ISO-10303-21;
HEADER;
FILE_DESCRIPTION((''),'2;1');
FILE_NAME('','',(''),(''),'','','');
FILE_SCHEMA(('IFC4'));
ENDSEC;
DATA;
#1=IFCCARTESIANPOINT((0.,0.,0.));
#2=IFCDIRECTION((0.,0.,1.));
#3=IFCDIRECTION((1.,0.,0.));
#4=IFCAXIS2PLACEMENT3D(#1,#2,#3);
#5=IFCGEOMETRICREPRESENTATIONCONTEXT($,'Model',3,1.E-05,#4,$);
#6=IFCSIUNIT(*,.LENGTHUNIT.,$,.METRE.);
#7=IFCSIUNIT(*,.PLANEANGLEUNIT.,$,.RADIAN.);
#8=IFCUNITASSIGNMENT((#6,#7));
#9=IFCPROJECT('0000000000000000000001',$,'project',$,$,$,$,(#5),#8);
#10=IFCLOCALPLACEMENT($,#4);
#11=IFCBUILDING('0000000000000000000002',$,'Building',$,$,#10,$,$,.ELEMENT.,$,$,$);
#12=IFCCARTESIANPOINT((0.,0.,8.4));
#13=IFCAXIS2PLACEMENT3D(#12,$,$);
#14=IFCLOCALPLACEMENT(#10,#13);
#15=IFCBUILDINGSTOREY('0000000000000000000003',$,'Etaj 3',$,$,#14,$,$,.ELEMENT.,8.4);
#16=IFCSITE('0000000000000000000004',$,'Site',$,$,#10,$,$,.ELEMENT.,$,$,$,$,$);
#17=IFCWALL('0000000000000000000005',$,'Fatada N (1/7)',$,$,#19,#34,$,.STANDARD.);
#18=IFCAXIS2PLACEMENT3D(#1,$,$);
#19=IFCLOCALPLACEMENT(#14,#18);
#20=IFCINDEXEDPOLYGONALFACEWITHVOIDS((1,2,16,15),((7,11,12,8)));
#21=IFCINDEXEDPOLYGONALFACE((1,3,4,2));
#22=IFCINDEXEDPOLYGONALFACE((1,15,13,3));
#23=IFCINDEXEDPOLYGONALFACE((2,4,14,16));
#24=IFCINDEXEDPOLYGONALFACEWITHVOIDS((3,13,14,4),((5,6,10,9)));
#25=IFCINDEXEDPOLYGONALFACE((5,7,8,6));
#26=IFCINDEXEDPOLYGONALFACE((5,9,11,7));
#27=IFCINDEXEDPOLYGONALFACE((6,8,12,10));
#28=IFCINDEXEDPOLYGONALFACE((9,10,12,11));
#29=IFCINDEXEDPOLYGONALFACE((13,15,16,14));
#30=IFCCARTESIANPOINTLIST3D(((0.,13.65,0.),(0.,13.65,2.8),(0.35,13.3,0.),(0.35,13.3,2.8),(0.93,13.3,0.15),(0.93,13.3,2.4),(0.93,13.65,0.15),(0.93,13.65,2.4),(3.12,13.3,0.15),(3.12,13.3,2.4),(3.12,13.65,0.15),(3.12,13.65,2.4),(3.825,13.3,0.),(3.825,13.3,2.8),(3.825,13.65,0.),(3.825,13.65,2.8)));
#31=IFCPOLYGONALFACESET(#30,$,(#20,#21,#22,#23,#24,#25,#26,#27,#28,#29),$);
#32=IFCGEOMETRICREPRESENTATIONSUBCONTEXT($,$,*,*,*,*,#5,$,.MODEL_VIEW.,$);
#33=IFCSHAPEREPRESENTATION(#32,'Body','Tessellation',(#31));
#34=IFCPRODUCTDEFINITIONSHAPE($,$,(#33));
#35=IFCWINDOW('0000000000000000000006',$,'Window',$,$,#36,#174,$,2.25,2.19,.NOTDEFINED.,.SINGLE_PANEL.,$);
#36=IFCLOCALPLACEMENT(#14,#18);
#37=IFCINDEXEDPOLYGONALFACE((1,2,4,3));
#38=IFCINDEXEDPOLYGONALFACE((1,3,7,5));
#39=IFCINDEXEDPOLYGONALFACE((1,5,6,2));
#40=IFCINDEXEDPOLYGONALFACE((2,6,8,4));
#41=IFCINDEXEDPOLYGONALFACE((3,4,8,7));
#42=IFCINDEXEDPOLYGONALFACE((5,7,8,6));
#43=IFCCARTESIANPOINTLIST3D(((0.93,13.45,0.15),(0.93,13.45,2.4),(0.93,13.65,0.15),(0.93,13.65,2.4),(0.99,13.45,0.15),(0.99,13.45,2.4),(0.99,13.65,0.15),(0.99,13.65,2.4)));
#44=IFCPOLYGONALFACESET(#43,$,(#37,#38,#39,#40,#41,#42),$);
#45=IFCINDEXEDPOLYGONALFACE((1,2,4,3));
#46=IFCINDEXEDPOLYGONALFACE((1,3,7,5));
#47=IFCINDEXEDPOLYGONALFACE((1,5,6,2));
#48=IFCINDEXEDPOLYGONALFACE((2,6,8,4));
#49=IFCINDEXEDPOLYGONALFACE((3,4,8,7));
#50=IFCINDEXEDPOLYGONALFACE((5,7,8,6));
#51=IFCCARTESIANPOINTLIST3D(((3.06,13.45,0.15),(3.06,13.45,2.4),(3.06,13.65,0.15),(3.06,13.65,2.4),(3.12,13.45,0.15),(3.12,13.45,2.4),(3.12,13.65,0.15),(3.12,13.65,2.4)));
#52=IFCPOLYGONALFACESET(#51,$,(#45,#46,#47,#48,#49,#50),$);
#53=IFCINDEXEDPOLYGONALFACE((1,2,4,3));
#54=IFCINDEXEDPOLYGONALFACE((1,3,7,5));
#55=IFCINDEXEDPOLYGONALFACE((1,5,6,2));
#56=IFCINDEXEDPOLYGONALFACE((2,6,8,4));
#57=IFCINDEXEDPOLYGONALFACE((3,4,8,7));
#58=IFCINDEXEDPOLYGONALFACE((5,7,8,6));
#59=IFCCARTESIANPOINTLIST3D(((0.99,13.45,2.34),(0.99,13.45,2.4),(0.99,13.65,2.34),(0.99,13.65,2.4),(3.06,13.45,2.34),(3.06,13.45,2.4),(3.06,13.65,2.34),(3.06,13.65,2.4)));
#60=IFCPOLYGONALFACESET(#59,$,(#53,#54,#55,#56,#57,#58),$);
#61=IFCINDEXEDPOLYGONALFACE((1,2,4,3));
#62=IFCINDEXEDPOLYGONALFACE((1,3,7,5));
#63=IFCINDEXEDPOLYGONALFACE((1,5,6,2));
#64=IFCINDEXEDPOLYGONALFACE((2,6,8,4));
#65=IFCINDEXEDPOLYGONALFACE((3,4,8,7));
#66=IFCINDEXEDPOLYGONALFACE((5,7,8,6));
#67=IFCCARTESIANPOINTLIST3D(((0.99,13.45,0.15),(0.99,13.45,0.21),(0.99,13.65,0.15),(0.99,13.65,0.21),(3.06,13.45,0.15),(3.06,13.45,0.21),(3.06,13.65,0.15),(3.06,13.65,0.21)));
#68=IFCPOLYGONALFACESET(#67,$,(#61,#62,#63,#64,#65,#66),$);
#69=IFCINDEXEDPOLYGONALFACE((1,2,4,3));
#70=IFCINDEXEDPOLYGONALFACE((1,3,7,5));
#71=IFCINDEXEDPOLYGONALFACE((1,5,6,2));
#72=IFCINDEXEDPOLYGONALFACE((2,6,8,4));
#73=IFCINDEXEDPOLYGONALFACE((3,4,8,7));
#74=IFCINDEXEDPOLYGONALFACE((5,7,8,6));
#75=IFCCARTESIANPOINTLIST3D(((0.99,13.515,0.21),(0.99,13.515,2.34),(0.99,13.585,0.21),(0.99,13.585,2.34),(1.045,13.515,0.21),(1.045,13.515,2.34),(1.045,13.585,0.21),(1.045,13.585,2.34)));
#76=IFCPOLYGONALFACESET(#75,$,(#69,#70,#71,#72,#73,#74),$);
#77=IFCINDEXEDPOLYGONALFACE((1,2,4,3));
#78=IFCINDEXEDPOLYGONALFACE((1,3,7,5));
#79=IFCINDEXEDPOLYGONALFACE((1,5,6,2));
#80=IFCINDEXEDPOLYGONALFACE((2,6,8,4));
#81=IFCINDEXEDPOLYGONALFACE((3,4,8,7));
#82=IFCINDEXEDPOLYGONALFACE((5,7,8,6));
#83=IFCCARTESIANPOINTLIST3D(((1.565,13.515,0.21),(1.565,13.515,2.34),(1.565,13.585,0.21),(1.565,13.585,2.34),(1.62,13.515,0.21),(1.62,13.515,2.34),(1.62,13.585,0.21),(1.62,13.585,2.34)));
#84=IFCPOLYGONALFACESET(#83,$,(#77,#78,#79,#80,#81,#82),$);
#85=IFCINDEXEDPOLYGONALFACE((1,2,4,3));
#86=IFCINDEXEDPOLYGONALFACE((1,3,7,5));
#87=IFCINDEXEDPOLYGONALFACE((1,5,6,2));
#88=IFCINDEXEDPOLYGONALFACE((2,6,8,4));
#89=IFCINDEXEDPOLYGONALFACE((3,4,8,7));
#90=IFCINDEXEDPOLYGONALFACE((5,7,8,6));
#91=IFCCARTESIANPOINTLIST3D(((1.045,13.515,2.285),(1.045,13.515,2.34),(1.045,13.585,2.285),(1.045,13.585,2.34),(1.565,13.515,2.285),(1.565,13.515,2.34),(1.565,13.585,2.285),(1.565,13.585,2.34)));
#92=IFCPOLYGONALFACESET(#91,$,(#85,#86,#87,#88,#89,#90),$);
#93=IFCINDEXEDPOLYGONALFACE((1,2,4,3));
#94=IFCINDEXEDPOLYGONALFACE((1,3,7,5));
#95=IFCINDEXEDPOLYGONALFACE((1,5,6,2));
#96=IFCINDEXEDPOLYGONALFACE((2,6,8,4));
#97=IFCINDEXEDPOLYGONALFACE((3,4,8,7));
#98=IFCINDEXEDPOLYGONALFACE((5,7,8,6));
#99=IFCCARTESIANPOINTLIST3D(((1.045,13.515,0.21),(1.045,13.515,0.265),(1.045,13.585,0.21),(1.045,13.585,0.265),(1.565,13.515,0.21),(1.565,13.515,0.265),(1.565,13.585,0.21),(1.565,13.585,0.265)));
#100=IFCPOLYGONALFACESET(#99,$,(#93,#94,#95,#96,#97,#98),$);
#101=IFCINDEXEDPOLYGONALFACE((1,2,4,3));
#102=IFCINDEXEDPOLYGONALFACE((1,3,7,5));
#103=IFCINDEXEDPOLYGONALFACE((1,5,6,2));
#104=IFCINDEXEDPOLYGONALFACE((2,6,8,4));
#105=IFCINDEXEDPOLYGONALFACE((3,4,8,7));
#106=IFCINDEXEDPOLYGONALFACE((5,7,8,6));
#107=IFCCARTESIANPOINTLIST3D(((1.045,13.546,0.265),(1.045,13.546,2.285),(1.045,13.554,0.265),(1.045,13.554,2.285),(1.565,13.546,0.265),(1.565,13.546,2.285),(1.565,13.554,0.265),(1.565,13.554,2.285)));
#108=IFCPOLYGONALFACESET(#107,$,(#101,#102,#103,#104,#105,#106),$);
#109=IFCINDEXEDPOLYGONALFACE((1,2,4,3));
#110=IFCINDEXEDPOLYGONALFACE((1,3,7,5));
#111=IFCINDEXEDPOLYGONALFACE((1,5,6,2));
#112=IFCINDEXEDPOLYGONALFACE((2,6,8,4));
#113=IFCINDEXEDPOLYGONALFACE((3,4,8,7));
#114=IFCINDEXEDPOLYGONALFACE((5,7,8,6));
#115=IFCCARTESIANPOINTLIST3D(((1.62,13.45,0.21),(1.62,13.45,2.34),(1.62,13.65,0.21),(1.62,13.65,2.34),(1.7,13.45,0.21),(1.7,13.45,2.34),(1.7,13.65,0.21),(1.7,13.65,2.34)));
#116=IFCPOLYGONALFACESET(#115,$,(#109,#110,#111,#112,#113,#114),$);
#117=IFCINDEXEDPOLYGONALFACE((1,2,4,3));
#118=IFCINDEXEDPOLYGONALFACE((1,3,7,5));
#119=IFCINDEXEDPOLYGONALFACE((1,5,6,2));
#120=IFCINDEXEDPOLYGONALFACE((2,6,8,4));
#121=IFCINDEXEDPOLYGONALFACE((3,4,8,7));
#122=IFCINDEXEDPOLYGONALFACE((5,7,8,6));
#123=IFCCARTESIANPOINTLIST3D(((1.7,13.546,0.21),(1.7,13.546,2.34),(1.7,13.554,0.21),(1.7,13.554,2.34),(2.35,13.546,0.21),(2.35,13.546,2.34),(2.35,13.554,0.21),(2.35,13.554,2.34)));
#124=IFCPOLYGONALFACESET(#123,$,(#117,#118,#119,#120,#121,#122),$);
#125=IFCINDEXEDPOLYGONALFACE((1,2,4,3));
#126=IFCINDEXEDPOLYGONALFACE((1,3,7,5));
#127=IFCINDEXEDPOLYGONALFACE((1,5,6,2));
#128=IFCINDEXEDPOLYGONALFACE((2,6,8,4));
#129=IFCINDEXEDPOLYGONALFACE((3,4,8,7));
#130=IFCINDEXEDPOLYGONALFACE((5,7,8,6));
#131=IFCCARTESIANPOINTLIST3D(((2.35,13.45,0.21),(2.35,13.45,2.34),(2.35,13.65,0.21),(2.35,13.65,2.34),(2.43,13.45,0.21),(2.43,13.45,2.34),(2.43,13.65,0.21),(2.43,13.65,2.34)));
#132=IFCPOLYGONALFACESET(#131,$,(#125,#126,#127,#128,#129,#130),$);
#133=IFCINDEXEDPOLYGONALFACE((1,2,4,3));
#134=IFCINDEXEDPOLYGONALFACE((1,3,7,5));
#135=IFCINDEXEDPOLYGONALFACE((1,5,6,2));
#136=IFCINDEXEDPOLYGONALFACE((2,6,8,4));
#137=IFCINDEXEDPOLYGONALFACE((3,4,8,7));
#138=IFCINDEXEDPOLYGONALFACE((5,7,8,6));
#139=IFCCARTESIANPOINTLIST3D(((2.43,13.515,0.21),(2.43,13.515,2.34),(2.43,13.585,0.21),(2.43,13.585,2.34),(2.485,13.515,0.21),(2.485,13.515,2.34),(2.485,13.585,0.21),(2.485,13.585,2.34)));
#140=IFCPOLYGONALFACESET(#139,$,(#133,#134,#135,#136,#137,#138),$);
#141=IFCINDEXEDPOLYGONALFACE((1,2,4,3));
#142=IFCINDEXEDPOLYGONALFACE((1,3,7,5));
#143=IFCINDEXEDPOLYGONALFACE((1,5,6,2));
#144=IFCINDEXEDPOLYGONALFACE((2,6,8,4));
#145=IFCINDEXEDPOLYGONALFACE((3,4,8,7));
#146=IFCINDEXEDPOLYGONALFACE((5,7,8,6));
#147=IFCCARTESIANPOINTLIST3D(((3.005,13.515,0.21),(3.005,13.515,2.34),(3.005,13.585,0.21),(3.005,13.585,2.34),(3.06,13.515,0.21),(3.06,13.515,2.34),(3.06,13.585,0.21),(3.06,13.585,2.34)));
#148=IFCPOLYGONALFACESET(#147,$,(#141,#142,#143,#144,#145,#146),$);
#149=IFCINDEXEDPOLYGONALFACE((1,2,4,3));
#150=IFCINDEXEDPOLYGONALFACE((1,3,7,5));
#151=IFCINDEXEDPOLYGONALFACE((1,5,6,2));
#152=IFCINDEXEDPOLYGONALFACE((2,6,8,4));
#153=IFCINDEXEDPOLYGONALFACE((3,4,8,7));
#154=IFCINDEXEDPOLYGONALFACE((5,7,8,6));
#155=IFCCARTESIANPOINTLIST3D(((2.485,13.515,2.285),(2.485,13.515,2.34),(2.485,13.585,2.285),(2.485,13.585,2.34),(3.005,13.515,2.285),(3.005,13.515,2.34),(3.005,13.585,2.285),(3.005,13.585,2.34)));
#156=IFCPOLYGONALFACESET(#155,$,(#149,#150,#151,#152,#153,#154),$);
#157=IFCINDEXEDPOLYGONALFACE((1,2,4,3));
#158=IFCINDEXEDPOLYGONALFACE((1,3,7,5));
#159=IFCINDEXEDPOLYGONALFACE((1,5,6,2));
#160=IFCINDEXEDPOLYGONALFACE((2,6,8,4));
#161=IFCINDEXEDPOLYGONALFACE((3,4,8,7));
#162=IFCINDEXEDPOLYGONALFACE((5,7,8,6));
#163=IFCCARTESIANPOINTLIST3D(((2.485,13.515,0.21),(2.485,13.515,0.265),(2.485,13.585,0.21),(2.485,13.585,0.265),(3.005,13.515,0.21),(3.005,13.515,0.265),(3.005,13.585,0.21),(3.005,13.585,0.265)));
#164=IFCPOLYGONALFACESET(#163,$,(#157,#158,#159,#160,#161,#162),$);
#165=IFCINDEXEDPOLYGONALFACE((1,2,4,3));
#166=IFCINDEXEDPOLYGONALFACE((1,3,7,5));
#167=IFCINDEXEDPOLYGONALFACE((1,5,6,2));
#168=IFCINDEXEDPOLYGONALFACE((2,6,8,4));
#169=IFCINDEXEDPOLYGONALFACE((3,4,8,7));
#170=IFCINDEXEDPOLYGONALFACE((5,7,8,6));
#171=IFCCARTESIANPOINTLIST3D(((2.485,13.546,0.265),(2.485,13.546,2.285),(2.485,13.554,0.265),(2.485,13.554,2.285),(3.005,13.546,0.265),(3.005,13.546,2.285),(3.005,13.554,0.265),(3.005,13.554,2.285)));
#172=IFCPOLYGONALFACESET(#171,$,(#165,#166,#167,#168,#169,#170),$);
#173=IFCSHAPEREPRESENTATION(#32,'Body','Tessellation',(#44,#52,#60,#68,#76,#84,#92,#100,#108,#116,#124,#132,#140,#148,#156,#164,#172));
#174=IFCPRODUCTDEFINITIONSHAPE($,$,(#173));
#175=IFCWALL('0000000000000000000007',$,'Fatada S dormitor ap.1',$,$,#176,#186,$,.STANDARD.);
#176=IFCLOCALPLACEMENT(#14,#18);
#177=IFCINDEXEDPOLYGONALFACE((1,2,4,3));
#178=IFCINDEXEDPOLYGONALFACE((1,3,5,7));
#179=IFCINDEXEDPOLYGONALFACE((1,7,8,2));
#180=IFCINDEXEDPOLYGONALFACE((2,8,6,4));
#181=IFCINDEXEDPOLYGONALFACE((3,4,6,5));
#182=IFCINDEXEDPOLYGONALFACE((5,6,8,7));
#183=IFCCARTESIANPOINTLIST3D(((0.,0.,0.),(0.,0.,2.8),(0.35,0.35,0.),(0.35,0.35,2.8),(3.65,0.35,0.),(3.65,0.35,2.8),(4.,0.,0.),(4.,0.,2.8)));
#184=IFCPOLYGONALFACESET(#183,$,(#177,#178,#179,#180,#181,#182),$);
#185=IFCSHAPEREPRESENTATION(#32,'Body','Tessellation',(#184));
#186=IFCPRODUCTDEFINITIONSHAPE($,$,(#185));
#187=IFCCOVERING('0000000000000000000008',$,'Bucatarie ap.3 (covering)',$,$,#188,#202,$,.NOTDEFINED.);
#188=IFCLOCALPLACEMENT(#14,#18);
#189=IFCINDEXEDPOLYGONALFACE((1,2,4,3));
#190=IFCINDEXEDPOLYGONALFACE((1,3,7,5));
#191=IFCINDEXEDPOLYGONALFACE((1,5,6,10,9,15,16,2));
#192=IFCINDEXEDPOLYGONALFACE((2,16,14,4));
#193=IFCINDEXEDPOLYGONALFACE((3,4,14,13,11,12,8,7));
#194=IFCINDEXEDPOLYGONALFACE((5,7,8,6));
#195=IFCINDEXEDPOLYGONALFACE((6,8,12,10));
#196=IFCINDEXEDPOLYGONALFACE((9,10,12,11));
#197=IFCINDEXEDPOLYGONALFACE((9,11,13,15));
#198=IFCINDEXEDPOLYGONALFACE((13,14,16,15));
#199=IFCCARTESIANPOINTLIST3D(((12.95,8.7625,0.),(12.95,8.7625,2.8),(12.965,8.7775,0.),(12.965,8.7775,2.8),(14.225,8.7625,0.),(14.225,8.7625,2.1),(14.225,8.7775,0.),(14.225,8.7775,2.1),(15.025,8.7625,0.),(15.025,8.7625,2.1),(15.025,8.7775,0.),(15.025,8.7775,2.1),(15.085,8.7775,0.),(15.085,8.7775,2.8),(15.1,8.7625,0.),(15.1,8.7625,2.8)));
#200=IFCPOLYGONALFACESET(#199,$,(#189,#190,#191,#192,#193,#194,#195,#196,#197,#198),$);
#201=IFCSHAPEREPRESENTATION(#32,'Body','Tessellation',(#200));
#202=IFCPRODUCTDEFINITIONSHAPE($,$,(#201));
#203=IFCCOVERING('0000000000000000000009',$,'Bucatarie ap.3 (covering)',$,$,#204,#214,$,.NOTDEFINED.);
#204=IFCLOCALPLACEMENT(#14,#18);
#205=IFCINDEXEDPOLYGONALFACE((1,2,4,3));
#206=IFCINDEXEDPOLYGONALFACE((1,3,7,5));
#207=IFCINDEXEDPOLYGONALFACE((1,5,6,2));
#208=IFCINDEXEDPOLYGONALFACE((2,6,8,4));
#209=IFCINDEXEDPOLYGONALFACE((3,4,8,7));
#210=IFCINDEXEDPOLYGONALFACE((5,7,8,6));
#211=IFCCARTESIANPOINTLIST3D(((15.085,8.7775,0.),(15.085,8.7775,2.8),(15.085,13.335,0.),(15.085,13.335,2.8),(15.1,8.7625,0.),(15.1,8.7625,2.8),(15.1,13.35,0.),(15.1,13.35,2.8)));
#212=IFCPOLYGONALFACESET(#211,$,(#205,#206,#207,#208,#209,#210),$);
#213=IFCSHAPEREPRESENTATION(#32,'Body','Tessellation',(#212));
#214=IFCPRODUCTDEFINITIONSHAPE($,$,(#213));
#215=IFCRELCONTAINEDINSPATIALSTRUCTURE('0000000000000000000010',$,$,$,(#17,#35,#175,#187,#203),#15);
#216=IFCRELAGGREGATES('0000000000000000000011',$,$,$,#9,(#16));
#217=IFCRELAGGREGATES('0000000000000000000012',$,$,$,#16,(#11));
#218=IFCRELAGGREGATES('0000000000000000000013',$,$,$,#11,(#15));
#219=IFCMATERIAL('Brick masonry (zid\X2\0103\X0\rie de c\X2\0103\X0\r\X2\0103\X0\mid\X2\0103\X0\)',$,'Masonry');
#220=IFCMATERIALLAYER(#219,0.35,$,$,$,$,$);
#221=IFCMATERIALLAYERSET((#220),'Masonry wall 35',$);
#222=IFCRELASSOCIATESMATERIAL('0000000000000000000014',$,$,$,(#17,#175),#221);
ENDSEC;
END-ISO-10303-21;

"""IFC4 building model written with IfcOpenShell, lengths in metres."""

from ifc_helpers import new_model, si_unit, frame, frame_2d, origin, origin_with_axes, origin_2d, place, context, subcontext, project, spatial, polyline, rectangle, outline, extrude, clip, halfspace, material, layer, layer_set, layer_usage, element, fill, save


model = new_model("IFC4")

# Units and contexts
model_context = context("Model", 3, precision=1e-05, world=origin_with_axes())
sub_context = subcontext(model_context, None, None, "MODEL_VIEW")
ifc_project = project(units=[si_unit("LENGTHUNIT", "METRE"), si_unit("PLANEANGLEUNIT", "RADIAN")], contexts=[model_context])

# Site, building, storey
placement = place(None, origin_with_axes())
site = spatial("IfcSite", under=ifc_project, at=placement, Name="Site", CompositionType="ELEMENT")
building = spatial("IfcBuilding", under=site, at=placement, Name="Building", CompositionType="ELEMENT")
storey_placement = place(placement, frame((0.0, 0.0, 8.4)))
storey = spatial("IfcBuildingStorey", under=building, at=storey_placement, Name="Etaj 3", CompositionType="ELEMENT", Elevation=8.4)

# Wall, opening, window
ifc_material = material(Name="Brick masonry (zidărie de cărămidă)", Category="Masonry")
ifc_layer = layer(ifc_material, 0.35)
ifc_layer_set = layer_set([ifc_layer], Name="Masonry wall 35")
ifc_layer_usage = layer_usage(ifc_layer_set, "AXIS2", "POSITIVE", -0.175)
wall_1_placement = place(storey_placement, frame((0.0, 13.475, 0.0), x_axis=(1.0, 0.0, 0.0)))
wall_1 = element("IfcWall", 1, at=wall_1_placement, inside=storey, material=ifc_layer_usage, Name="Fatada N (1/7)", PredefinedType="STANDARD", context=sub_context, shape_type="CSG", body=[
    clip(extrude(rectangle(XDim=3.825, YDim=0.35, at=frame_2d((1.9125, 0.0))), origin(), (0.0, 0.0, 1.0), 2.8), halfspace(frame((0.175, 0.0, 0.0), z_axis=(-0.707107, -0.707107, 0.0)), False)),
])
opening_1_placement = place(wall_1_placement, frame((2.025, 0.225, 0.15), z_axis=(0.0, -1.0, 0.0), x_axis=(1.0, 0.0, 0.0)))
opening_1 = element("IfcOpeningElement", 2, at=opening_1_placement, cuts=wall_1, PredefinedType="OPENING", context=sub_context, shape_type="SweptSolid", body=[
    extrude(rectangle(XDim=2.19, YDim=2.25, at=frame_2d((0.0, 1.125))), origin(), (0.0, 0.0, 1.0), 0.45),
])
window_placement = place(wall_1_placement, frame((2.025, 0.175, 0.15), z_axis=(0.0, -1.0, 0.0), x_axis=(1.0, 0.0, 0.0)))
window = element("IfcWindow", 3, at=window_placement, inside=storey, Name="Window", OverallHeight=2.25, OverallWidth=2.19, PartitioningType="SINGLE_PANEL", PredefinedType="NOTDEFINED", context=sub_context, shape_type="SweptSolid", body=[
    extrude(rectangle(XDim=0.06, YDim=2.25, at=origin_2d()), frame((-1.065, 1.125, 0.0)), (0.0, 0.0, 1.0), 0.2),
    extrude(rectangle(XDim=0.06, YDim=2.25, at=origin_2d()), frame((1.065, 1.125, 0.0)), (0.0, 0.0, 1.0), 0.2),
    extrude(rectangle(XDim=2.07, YDim=0.06, at=origin_2d()), frame((0.0, 2.22, 0.0)), (0.0, 0.0, 1.0), 0.2),
    extrude(rectangle(XDim=2.07, YDim=0.06, at=origin_2d()), frame((0.0, 0.03, 0.0)), (0.0, 0.0, 1.0), 0.2),
    extrude(rectangle(XDim=0.055, YDim=2.13, at=origin_2d()), frame((-1.0075, 1.125, 0.065)), (0.0, 0.0, 1.0), 0.07),
    extrude(rectangle(XDim=0.055, YDim=2.13, at=origin_2d()), frame((-0.4325, 1.125, 0.065)), (0.0, 0.0, 1.0), 0.07),
    extrude(rectangle(XDim=0.52, YDim=0.055, at=origin_2d()), frame((-0.72, 2.1625, 0.065)), (0.0, 0.0, 1.0), 0.07),
    extrude(rectangle(XDim=0.52, YDim=0.055, at=origin_2d()), frame((-0.72, 0.0875, 0.065)), (0.0, 0.0, 1.0), 0.07),
    extrude(rectangle(XDim=0.52, YDim=2.02, at=origin_2d()), frame((-0.72, 1.125, 0.096)), (0.0, 0.0, 1.0), 0.008),
    extrude(rectangle(XDim=0.08, YDim=2.13, at=origin_2d()), frame((-0.365, 1.125, 0.0)), (0.0, 0.0, 1.0), 0.2),
    extrude(rectangle(XDim=0.65, YDim=2.13, at=origin_2d()), frame((0.0, 1.125, 0.096)), (0.0, 0.0, 1.0), 0.008),
    extrude(rectangle(XDim=0.08, YDim=2.13, at=origin_2d()), frame((0.365, 1.125, 0.0)), (0.0, 0.0, 1.0), 0.2),
    extrude(rectangle(XDim=0.055, YDim=2.13, at=origin_2d()), frame((0.4325, 1.125, 0.065)), (0.0, 0.0, 1.0), 0.07),
    extrude(rectangle(XDim=0.055, YDim=2.13, at=origin_2d()), frame((1.0075, 1.125, 0.065)), (0.0, 0.0, 1.0), 0.07),
    extrude(rectangle(XDim=0.52, YDim=0.055, at=origin_2d()), frame((0.72, 2.1625, 0.065)), (0.0, 0.0, 1.0), 0.07),
    extrude(rectangle(XDim=0.52, YDim=0.055, at=origin_2d()), frame((0.72, 0.0875, 0.065)), (0.0, 0.0, 1.0), 0.07),
    extrude(rectangle(XDim=0.52, YDim=2.02, at=origin_2d()), frame((0.72, 1.125, 0.096)), (0.0, 0.0, 1.0), 0.008),
])
fill(opening_1, window)

# Wall
wall_2_placement = place(storey_placement, frame((0.0, 0.175, 0.0), x_axis=(1.0, 0.0, 0.0)))
element("IfcWall", 4, at=wall_2_placement, inside=storey, material=ifc_layer_usage, Name="Fatada S dormitor ap.1", PredefinedType="STANDARD", context=sub_context, shape_type="CSG", body=[
    clip(clip(extrude(rectangle(XDim=4.0, YDim=0.35, at=frame_2d((2.0, 0.0))), origin(), (0.0, 0.0, 1.0), 2.8), halfspace(frame((0.175, 0.0, 0.0), z_axis=(-0.707107, 0.707107, 0.0)), False)), halfspace(frame((3.825, 0.0, 0.0), z_axis=(0.707107, 0.707107, 0.0)), False)),
])

# Covering, opening
covering_1_placement = place(storey_placement, origin_with_axes())
covering_1 = element("IfcCovering", 5, at=covering_1_placement, inside=storey, Name="Bucatarie ap.3 (covering)", PredefinedType="NOTDEFINED", context=sub_context, shape_type="SweptSolid", body=[
    extrude(outline(polyline([(12.95, 8.7625), (15.1, 8.7625), (15.085, 8.7775), (12.965, 8.7775), (12.95, 8.7625)])), origin(), (0.0, 0.0, 1.0), 2.8),
])
opening_2_placement = place(covering_1_placement, frame((14.625, 8.8275, 0.0), z_axis=(0.0, -1.0, 0.0), x_axis=(1.0, 0.0, 0.0)))
element("IfcOpeningElement", 6, at=opening_2_placement, cuts=covering_1, PredefinedType="OPENING", context=sub_context, shape_type="SweptSolid", body=[
    extrude(rectangle(XDim=0.8, YDim=2.1, at=origin_2d()), frame((0.0, 1.05, 0.0)), (0.0, 0.0, 1.0), 0.38),
])

# Covering
covering_2_placement = place(storey_placement, origin_with_axes())
element("IfcCovering", 7, at=covering_2_placement, inside=storey, Name="Bucatarie ap.3 (covering)", PredefinedType="NOTDEFINED", context=sub_context, shape_type="SweptSolid", body=[
    extrude(outline(polyline([(15.1, 8.7625), (15.1, 13.35), (15.085, 13.335), (15.085, 8.7775), (15.1, 8.7625)])), origin(), (0.0, 0.0, 1.0), 2.8),
])

save(model, "model.ifc")
